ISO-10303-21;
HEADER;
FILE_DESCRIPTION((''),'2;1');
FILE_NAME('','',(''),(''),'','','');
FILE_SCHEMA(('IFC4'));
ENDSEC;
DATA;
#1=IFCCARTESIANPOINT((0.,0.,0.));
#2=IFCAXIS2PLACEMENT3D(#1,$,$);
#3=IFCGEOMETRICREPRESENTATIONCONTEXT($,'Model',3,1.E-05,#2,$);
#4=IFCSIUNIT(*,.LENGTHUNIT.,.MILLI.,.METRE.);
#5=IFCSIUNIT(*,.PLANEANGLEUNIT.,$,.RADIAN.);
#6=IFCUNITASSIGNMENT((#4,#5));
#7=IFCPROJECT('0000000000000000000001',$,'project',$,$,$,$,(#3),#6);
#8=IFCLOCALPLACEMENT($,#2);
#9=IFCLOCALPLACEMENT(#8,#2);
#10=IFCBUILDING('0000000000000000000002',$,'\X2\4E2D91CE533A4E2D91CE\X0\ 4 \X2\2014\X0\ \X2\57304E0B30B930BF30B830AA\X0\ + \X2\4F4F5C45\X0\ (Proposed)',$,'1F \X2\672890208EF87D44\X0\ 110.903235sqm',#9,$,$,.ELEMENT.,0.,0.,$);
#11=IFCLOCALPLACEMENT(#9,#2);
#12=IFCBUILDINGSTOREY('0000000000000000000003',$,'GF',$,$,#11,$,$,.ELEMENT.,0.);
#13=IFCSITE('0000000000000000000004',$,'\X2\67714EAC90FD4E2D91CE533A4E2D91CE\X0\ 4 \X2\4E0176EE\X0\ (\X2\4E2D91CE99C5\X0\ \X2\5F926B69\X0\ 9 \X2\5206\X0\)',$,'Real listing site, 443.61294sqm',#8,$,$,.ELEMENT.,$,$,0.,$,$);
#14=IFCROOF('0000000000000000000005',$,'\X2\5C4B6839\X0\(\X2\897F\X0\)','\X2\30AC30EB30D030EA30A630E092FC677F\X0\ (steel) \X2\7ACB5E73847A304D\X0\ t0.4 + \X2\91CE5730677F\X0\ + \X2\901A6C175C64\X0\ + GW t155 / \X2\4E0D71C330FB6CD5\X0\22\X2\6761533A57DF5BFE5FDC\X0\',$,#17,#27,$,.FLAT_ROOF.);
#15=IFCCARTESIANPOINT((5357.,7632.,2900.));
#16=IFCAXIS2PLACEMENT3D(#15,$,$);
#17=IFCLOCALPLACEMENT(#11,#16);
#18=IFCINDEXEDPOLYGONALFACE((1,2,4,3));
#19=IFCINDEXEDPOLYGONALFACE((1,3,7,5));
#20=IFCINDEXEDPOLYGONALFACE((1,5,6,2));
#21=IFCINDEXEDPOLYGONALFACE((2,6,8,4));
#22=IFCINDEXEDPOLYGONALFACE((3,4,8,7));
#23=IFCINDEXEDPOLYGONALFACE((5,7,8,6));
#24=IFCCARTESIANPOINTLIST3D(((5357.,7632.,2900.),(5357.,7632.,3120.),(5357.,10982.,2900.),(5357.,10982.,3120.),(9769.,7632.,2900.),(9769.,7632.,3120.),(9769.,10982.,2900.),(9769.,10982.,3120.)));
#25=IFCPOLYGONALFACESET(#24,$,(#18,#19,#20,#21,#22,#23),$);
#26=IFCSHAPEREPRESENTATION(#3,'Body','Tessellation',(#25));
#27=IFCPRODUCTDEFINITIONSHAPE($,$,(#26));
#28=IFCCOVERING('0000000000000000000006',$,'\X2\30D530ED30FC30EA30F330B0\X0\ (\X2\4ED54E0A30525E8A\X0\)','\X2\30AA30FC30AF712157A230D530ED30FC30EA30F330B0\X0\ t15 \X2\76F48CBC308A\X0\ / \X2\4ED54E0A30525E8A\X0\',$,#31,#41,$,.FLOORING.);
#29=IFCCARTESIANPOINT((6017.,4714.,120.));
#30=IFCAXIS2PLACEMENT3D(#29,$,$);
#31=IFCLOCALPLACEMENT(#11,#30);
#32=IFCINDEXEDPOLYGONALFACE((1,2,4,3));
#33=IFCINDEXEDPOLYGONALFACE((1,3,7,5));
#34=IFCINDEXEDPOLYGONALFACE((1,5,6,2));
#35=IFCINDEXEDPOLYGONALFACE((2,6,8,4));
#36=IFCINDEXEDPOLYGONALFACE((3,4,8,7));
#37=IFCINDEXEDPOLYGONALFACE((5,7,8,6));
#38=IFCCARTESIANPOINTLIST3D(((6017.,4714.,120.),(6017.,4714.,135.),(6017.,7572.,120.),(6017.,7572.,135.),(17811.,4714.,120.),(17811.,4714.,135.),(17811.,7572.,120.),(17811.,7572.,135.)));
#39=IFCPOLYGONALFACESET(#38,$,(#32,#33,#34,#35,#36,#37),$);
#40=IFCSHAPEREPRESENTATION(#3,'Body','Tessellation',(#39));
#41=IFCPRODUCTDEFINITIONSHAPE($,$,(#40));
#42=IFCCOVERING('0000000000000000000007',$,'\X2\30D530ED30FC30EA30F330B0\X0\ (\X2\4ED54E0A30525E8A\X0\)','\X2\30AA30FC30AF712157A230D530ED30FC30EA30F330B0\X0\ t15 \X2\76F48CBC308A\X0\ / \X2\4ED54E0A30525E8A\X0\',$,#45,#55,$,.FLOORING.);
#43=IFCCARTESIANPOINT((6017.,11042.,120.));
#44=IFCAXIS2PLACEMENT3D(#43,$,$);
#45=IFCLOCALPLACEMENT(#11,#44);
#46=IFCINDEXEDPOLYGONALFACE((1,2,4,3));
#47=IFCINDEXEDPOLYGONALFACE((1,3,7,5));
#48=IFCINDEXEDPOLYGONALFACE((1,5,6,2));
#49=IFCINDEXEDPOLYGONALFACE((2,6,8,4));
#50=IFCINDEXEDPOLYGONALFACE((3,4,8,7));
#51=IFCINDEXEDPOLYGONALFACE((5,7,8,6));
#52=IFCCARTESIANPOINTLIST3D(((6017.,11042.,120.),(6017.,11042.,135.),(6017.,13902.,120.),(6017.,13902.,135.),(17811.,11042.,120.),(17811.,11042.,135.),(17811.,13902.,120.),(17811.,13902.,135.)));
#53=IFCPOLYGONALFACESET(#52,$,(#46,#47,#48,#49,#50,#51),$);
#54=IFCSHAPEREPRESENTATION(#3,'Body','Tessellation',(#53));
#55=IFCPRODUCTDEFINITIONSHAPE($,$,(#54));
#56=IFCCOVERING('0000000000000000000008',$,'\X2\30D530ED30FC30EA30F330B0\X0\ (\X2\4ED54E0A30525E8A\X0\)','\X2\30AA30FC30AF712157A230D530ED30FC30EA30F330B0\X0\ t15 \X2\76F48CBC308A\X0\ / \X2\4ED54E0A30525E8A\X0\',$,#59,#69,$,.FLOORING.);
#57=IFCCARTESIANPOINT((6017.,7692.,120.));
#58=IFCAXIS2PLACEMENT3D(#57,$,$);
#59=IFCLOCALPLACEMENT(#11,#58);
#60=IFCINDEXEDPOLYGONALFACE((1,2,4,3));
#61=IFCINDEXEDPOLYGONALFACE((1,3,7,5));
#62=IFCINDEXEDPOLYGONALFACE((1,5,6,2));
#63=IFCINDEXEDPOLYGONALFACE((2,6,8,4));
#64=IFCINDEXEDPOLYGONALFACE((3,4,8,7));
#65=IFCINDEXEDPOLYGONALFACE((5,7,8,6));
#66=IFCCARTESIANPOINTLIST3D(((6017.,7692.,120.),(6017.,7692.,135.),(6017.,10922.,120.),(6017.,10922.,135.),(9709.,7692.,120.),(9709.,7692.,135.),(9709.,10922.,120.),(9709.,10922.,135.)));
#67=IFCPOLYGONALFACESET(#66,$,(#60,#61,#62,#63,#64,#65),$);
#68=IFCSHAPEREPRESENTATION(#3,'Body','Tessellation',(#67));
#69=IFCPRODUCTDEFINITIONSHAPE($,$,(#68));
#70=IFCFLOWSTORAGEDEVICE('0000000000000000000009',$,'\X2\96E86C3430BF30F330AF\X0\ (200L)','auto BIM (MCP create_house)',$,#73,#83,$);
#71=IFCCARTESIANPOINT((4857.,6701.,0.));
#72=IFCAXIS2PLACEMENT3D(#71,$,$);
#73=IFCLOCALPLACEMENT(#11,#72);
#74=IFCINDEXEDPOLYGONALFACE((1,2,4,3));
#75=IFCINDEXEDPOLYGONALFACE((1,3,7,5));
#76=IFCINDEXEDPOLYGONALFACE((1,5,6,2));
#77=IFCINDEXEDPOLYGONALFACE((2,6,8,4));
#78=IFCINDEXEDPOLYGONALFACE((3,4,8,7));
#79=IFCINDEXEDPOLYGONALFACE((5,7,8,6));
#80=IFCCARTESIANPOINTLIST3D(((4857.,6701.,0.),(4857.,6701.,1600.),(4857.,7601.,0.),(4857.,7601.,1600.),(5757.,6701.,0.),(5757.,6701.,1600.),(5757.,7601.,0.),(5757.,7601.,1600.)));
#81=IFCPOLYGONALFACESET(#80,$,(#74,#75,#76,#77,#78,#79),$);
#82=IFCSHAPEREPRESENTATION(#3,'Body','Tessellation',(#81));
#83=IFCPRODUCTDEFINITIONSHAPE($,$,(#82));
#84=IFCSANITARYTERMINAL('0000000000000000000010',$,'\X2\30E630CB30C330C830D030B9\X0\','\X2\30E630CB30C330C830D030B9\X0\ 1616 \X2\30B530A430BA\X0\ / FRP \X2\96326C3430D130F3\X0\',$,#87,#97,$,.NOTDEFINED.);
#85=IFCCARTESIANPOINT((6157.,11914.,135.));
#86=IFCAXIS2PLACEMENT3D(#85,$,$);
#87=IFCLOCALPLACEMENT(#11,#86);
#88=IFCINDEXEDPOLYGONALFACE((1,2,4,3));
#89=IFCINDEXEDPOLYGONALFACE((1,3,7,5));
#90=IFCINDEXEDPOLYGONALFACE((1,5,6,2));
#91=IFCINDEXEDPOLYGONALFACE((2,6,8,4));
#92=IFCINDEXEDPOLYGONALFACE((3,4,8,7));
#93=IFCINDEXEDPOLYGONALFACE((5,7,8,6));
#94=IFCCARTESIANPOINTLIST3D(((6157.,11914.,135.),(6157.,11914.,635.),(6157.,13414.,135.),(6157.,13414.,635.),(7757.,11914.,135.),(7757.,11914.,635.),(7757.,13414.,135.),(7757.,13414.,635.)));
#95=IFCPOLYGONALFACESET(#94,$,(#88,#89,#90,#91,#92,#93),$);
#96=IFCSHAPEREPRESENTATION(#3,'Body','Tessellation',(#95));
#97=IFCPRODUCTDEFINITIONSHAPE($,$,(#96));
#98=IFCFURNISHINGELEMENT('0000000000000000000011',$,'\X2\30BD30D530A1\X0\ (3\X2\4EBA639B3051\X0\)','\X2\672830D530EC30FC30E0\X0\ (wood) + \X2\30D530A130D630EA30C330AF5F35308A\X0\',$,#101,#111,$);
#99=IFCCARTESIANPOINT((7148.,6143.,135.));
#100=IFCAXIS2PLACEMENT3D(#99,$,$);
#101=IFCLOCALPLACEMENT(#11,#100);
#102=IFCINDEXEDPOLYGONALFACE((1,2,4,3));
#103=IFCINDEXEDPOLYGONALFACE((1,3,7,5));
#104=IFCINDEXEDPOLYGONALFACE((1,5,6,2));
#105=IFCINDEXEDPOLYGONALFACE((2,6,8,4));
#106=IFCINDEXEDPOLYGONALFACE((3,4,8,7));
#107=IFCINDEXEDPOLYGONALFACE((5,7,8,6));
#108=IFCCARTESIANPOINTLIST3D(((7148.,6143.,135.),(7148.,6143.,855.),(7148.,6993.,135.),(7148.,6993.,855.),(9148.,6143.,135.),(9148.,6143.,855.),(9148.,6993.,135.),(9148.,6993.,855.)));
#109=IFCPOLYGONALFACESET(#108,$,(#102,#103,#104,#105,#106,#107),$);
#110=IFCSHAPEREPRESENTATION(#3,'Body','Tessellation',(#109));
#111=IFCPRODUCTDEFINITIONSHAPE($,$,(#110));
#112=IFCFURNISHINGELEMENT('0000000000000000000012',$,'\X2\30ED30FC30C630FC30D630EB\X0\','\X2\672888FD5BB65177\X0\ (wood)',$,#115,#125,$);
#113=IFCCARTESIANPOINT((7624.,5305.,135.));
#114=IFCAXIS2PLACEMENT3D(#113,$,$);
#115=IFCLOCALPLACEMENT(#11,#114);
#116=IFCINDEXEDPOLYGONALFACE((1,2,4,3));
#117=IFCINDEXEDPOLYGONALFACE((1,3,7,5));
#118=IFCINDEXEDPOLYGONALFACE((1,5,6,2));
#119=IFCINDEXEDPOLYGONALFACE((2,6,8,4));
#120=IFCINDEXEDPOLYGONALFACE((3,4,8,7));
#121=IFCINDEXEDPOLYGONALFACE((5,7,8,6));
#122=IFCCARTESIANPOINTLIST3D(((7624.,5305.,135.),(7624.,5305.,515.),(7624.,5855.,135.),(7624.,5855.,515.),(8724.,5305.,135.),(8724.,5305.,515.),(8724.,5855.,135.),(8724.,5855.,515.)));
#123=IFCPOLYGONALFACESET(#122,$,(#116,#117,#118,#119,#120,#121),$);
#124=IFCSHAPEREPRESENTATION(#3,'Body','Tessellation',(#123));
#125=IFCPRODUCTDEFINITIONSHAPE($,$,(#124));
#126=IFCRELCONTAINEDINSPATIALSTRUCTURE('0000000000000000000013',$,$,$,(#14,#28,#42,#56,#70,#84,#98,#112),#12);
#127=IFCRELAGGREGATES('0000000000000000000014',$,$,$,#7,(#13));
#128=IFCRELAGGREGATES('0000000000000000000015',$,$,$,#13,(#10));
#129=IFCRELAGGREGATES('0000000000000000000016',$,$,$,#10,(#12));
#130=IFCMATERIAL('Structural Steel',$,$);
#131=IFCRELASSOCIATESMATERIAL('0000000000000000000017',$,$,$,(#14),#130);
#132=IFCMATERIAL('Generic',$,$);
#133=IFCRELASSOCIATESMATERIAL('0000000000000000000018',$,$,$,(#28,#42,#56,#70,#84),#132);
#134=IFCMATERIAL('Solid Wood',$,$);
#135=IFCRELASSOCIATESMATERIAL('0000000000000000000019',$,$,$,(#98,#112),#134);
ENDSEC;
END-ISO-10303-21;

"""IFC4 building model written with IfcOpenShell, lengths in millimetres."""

from ifc_helpers import new_model, si_unit, frame, frame_2d, origin, place, context, project, spatial, rectangle, extrude, material, element, save


model = new_model("IFC4")

# Units and contexts
model_context = context("Model", 3, precision=1e-05, world=origin())
ifc_project = project(units=[si_unit("LENGTHUNIT", "METRE", prefix="MILLI"), si_unit("PLANEANGLEUNIT", "RADIAN")], contexts=[model_context])

# Site, building, storey
site_placement = place(None, origin())
site = spatial("IfcSite", under=ifc_project, at=site_placement, Name="東京都中野区中野 4 丁目 (中野駅 徒歩 9 分)", ObjectType="Real listing site, 443.61294sqm", CompositionType="ELEMENT", RefElevation=0.0)
building_placement = place(site_placement, origin())
building = spatial("IfcBuilding", under=site, at=building_placement, Name="中野区中野 4 — 地下スタジオ + 住居 (Proposed)", ObjectType="1F 木造軸組 110.903235sqm", CompositionType="ELEMENT", ElevationOfRefHeight=0.0, ElevationOfTerrain=0.0)
storey_placement = place(building_placement, origin())
storey = spatial("IfcBuildingStorey", under=building, at=storey_placement, Name="GF", CompositionType="ELEMENT", Elevation=0.0)

# Shared definitions
ifc_material_1 = material(Name="Solid Wood")

# Roof
ifc_material_2 = material(Name="Structural Steel")
roof_1_placement = place(storey_placement, frame((5357.0, 7632.0, 2900.0)))
element("IfcRoof", 1, at=roof_1_placement, inside=storey, material=ifc_material_2, Name="屋根(西)", Description="ガルバリウム鋼板 (steel) 立平葺き t0.4 + 野地板 + 通気層 + GW t155 / 不燃・法22条区域対応", PredefinedType="FLAT_ROOF", context=model_context, shape_type="SweptSolid", body=[
    extrude(rectangle(XDim=4412.0, YDim=3350.0, at=frame_2d((2206.0, 1675.0))), frame((5357.0, 7632.0, 2900.0)), (0.0, 0.0, 1.0), 220.0),
])

# Coverings
ifc_material_3 = material(Name="Generic")
covering_1_placement = place(storey_placement, frame((6017.0, 4714.0, 120.0)))
element("IfcCovering", 2, at=covering_1_placement, inside=storey, material=ifc_material_3, Name="フローリング (仕上げ床)", Description="オーク無垢フローリング t15 直貼り / 仕上げ床", PredefinedType="FLOORING", context=model_context, shape_type="SweptSolid", body=[
    extrude(rectangle(XDim=11794.0, YDim=2858.0, at=frame_2d((5897.0, 1429.0))), frame((6017.0, 4714.0, 120.0)), (0.0, 0.0, 1.0), 15.0),
])
covering_2_placement = place(storey_placement, frame((6017.0, 11042.0, 120.0)))
element("IfcCovering", 3, at=covering_2_placement, inside=storey, material=ifc_material_3, Name="フローリング (仕上げ床)", Description="オーク無垢フローリング t15 直貼り / 仕上げ床", PredefinedType="FLOORING", context=model_context, shape_type="SweptSolid", body=[
    extrude(rectangle(XDim=11794.0, YDim=2860.0, at=frame_2d((5897.0, 1430.0))), frame((6017.0, 11042.0, 120.0)), (0.0, 0.0, 1.0), 15.0),
])
covering_3_placement = place(storey_placement, frame((6017.0, 7692.0, 120.0)))
element("IfcCovering", 4, at=covering_3_placement, inside=storey, material=ifc_material_3, Name="フローリング (仕上げ床)", Description="オーク無垢フローリング t15 直貼り / 仕上げ床", PredefinedType="FLOORING", context=model_context, shape_type="SweptSolid", body=[
    extrude(rectangle(XDim=3692.0, YDim=3230.0, at=frame_2d((1846.0, 1615.0))), frame((6017.0, 7692.0, 120.0)), (0.0, 0.0, 1.0), 15.0),
])

# Flow storage device
flow_storage_device_placement = place(storey_placement, frame((4857.0, 6701.0, 0.0)))
element("IfcFlowStorageDevice", 5, at=flow_storage_device_placement, inside=storey, material=ifc_material_3, Name="雨水タンク (200L)", Description="auto BIM (MCP create_house)", context=model_context, shape_type="SweptSolid", body=[
    extrude(rectangle(XDim=900.0, YDim=900.0, at=frame_2d((450.0, 450.0))), frame((4857.0, 6701.0, 0.0)), (0.0, 0.0, 1.0), 1600.0),
])

# Sanitary terminal
sanitary_terminal_placement = place(storey_placement, frame((6157.0, 11914.0, 135.0)))
element("IfcSanitaryTerminal", 6, at=sanitary_terminal_placement, inside=storey, material=ifc_material_3, Name="ユニットバス", Description="ユニットバス 1616 サイズ / FRP 防水パン", PredefinedType="NOTDEFINED", context=model_context, shape_type="SweptSolid", body=[
    extrude(rectangle(XDim=1600.0, YDim=1500.0, at=frame_2d((800.0, 750.0))), frame((6157.0, 11914.0, 135.0)), (0.0, 0.0, 1.0), 500.0),
])

# Furnishing elements
furnishing_1_placement = place(storey_placement, frame((7148.0, 6143.0, 135.0)))
element("IfcFurnishingElement", 7, at=furnishing_1_placement, inside=storey, material=ifc_material_1, Name="ソファ (3人掛け)", Description="木フレーム (wood) + ファブリック張り", context=model_context, shape_type="SweptSolid", body=[
    extrude(rectangle(XDim=2000.0, YDim=850.0, at=frame_2d((1000.0, 425.0))), frame((7148.0, 6143.0, 135.0)), (0.0, 0.0, 1.0), 720.0),
])
furnishing_2_placement = place(storey_placement, frame((7624.0, 5305.0, 135.0)))
element("IfcFurnishingElement", 8, at=furnishing_2_placement, inside=storey, material=ifc_material_1, Name="ローテーブル", Description="木製家具 (wood)", context=model_context, shape_type="SweptSolid", body=[
    extrude(rectangle(XDim=1100.0, YDim=550.0, at=frame_2d((550.0, 275.0))), frame((7624.0, 5305.0, 135.0)), (0.0, 0.0, 1.0), 380.0),
])

save(model, "model.ifc")
